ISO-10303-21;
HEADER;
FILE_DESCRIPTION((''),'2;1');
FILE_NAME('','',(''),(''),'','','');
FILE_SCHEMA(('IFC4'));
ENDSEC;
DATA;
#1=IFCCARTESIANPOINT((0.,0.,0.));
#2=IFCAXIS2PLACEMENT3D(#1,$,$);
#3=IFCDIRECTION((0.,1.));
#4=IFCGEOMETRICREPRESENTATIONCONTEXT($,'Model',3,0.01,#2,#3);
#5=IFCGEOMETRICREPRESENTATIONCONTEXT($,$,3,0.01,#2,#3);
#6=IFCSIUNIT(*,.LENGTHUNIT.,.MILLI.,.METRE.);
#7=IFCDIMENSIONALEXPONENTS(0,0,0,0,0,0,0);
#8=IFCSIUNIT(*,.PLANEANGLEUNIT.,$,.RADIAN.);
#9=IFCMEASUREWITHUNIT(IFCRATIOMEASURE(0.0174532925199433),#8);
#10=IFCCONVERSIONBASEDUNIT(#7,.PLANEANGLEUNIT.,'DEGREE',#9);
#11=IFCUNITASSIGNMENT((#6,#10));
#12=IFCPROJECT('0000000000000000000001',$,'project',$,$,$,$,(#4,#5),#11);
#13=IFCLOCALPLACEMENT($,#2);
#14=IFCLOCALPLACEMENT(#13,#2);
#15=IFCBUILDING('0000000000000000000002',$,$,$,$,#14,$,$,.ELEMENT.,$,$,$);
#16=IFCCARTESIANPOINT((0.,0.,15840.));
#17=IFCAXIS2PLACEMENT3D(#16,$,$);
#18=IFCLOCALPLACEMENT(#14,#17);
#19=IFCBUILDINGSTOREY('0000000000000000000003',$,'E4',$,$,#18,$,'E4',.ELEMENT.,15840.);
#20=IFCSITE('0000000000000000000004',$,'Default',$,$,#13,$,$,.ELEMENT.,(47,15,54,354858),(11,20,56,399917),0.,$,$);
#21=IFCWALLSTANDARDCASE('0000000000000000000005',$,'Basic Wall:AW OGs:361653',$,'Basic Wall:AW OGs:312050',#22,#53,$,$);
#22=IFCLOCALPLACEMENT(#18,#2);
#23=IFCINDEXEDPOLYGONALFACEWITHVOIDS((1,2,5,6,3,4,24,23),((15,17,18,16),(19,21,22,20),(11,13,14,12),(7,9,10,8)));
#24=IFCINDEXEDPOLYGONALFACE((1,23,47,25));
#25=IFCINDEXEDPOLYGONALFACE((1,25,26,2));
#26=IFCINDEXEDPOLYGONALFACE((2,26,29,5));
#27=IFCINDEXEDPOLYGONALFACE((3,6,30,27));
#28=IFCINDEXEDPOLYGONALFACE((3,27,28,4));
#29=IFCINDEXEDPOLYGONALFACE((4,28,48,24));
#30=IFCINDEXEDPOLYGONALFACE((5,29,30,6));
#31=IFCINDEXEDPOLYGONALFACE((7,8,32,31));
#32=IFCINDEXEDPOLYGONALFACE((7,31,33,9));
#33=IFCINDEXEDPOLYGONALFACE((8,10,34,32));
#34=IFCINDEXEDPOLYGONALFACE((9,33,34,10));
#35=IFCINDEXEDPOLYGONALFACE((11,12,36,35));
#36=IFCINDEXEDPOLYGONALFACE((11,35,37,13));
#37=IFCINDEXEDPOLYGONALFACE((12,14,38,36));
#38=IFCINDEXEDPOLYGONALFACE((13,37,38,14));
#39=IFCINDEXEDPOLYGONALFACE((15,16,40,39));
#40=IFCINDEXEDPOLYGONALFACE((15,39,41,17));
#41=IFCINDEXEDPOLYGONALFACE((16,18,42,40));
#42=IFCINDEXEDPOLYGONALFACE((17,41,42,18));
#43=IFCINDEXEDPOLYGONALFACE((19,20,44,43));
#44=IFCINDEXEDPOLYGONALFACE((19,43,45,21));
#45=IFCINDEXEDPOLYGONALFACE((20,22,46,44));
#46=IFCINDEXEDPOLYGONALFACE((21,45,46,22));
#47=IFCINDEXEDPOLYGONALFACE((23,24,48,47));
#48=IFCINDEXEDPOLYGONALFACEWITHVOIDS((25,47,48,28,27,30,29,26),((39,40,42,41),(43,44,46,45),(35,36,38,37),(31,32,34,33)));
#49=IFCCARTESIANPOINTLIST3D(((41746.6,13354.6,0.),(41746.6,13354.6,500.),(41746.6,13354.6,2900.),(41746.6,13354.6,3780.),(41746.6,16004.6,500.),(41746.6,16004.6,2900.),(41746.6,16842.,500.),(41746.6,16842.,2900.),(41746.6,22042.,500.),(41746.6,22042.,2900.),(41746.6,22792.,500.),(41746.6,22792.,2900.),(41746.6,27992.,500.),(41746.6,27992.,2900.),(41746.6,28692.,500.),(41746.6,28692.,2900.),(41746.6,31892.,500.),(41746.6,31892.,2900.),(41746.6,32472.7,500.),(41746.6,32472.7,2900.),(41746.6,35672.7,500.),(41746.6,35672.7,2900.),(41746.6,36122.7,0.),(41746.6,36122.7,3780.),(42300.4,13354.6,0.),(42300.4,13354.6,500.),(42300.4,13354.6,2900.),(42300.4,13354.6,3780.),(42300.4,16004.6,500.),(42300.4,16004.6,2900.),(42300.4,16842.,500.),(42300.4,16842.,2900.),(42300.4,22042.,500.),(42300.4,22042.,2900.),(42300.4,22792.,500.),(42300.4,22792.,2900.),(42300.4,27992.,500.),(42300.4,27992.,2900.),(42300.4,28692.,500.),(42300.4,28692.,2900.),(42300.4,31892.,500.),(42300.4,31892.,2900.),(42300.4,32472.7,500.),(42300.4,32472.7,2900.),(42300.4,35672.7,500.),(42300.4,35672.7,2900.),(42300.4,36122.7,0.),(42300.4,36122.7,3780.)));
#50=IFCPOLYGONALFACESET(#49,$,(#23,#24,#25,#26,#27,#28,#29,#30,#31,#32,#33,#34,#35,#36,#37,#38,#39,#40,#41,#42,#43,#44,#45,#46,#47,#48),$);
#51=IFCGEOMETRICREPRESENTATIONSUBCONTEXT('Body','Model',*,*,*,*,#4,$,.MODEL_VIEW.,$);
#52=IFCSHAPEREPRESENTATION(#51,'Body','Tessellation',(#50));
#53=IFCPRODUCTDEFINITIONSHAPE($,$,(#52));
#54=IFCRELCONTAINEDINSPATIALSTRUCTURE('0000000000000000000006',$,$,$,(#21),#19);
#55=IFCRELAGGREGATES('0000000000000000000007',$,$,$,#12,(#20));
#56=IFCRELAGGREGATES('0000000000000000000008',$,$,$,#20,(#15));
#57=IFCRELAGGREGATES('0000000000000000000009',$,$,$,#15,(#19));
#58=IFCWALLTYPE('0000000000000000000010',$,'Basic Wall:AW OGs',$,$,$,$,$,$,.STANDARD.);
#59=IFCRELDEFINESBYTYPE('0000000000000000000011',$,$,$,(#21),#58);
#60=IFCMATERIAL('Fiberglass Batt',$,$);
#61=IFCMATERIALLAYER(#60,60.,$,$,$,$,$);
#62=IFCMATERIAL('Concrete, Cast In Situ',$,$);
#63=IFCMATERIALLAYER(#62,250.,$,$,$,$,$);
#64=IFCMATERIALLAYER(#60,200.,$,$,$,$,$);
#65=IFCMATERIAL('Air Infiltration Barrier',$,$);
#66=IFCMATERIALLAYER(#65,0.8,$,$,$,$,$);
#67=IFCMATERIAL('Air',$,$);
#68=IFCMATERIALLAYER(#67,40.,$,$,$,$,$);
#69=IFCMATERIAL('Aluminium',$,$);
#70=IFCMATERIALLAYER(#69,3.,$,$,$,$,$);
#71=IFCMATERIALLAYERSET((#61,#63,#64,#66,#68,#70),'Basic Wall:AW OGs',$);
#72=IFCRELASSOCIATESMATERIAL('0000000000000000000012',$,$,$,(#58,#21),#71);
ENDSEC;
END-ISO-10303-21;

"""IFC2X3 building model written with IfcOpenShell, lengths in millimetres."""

from ifc_helpers import new_model, entity, si_unit, converted_unit, direction, frame, frame_2d, origin, place, context, subcontext, project, spatial, rectangle, extrude, material, layer, layer_set, layer_usage, type_object, element, save


model = new_model("IFC2X3")

# Units and contexts
model_context = context("Model", 3, precision=0.01, world=origin(), true_north=direction((0.0, 1.0)))
context_of_model = context(None, 3, precision=0.01, world=origin(), true_north=direction((0.0, 1.0)))
body_context = subcontext(model_context, "Body", "Model", "MODEL_VIEW")
ifc_project = project(units=[si_unit("LENGTHUNIT", "METRE", prefix="MILLI"), converted_unit("PLANEANGLEUNIT", "DEGREE", entity("IfcRatioMeasure", 0.0174532925199433), si_unit("PLANEANGLEUNIT", "RADIAN"), dimensions=[0, 0, 0, 0, 0, 0, 0])], contexts=[model_context, context_of_model])

# Site, building, storey
site_placement = place(None, origin())
site = spatial("IfcSite", under=ifc_project, at=site_placement, Name="Default", CompositionType="ELEMENT", RefLatitude=(47, 15, 54, 354858), RefLongitude=(11, 20, 56, 399917), RefElevation=0.0)
building_placement = place(site_placement, origin())
building = spatial("IfcBuilding", under=site, at=building_placement, CompositionType="ELEMENT")
storey_placement = place(building_placement, frame((0.0, 0.0, 15840.0)))
storey = spatial("IfcBuildingStorey", under=building, at=storey_placement, Name="E4", LongName="E4", CompositionType="ELEMENT", Elevation=15840.0)

# Shared definitions
ifc_material_1 = material(Name="Air Infiltration Barrier")
ifc_material_2 = material(Name="Fiberglass Batt")

# Shared definitions
ifc_material_3 = material(Name="Aluminium")

# Wall, openings
ifc_layer_1 = layer(ifc_material_2, 60.0)
ifc_material_4 = material(Name="Concrete, Cast In Situ")
ifc_layer_2 = layer(ifc_material_4, 250.0)
ifc_layer_3 = layer(ifc_material_2, 200.0)
ifc_layer_4 = layer(ifc_material_1, 0.8)
ifc_material_5 = material(Name="Air")
ifc_layer_5 = layer(ifc_material_5, 40.0)
ifc_layer_6 = layer(ifc_material_3, 3.0)
ifc_layer_set_1 = layer_set([ifc_layer_1, ifc_layer_2, ifc_layer_3, ifc_layer_4, ifc_layer_5, ifc_layer_6], Name="Basic Wall:AW OGs")
wall_type = type_object("IfcWallType", Name="Basic Wall:AW OGs", PredefinedType="STANDARD", material=ifc_layer_set_1)
ifc_layer_usage_1 = layer_usage(ifc_layer_set_1, "AXIS2", "NEGATIVE", 276.9)
wall_1_placement = place(storey_placement, frame((42023.5, 36122.7, 0.0), z_axis=(0.0, 0.0, 1.0), x_axis=(0.0, -1.0, 0.0)))
wall_1 = element("IfcWallStandardCase", 1, at=wall_1_placement, inside=storey, type_object=wall_type, material=ifc_layer_usage_1, Name="Basic Wall:AW OGs:361653", ObjectType="Basic Wall:AW OGs:312050", context=body_context, shape_type="SweptSolid", body=[
    extrude(rectangle(XDim=22768.1, YDim=553.8, at=frame_2d((11384.0, 0.0), x_axis=(-1.0, 0.0))), origin(), (0.0, 0.0, 1.0), 3780.0),
])
opening_1_placement = place(wall_1_placement, origin())
element("IfcOpeningElement", 2, at=opening_1_placement, cuts=wall_1, ObjectType="Opening", context=body_context, shape_type="SweptSolid", body=[
    extrude(rectangle(XDim=2400.0, YDim=553.8, at=frame_2d((0.0, 0.0), x_axis=(0.0, 1.0))), frame((23045.0, 276.9, 1700.0), z_axis=(0.0, 1.0, 0.0), x_axis=(1.0, 0.0, 0.0)), (0.0, 0.0, 1.0), 5200.0),
])
opening_2_placement = place(wall_1_placement, frame((22768.1, 276.9, 500.0)))
element("IfcOpeningElement", 3, at=opening_2_placement, cuts=wall_1, ObjectType="Opening", context=body_context, shape_type="SweptSolid", body=[
    extrude(rectangle(XDim=2400.0, YDim=2650.0, at=frame_2d((1200.0, 1325.0), x_axis=(-1.0, 0.0))), frame((0.0, 0.0, 0.0), z_axis=(0.0, -1.0, 0.0), x_axis=(0.0, 0.0, 1.0)), (0.0, 0.0, 1.0), 553.8),
])
opening_3_placement = place(wall_1_placement, frame((19280.7, 276.9, 500.0)))
element("IfcOpeningElement", 4, at=opening_3_placement, cuts=wall_1, ObjectType="Opening", context=body_context, shape_type="SweptSolid", body=[
    extrude(rectangle(XDim=2400.0, YDim=5200.0, at=frame_2d((1200.0, 2600.0), x_axis=(-1.0, 0.0))), frame((0.0, 0.0, 0.0), z_axis=(0.0, -1.0, 0.0), x_axis=(0.0, 0.0, 1.0)), (0.0, 0.0, 1.0), 553.8),
])
opening_4_placement = place(wall_1_placement, frame((13330.7, 276.9, 500.0)))
element("IfcOpeningElement", 5, at=opening_4_placement, cuts=wall_1, ObjectType="Opening", context=body_context, shape_type="SweptSolid", body=[
    extrude(rectangle(XDim=2400.0, YDim=5200.0, at=frame_2d((1200.0, 2600.0), x_axis=(-1.0, 0.0))), frame((0.0, 0.0, 0.0), z_axis=(0.0, -1.0, 0.0), x_axis=(0.0, 0.0, 1.0)), (0.0, 0.0, 1.0), 553.8),
])
opening_5_placement = place(wall_1_placement, frame((7430.7, 276.9, 500.0)))
element("IfcOpeningElement", 6, at=opening_5_placement, cuts=wall_1, ObjectType="Opening", context=body_context, shape_type="SweptSolid", body=[
    extrude(rectangle(XDim=2400.0, YDim=3200.0, at=frame_2d((1200.0, 1600.0), x_axis=(-1.0, 0.0))), frame((0.0, 0.0, 0.0), z_axis=(0.0, -1.0, 0.0), x_axis=(0.0, 0.0, 1.0)), (0.0, 0.0, 1.0), 553.8),
])
opening_6_placement = place(wall_1_placement, frame((3650.0, 276.9, 500.0)))
element("IfcOpeningElement", 7, at=opening_6_placement, cuts=wall_1, ObjectType="Opening", context=body_context, shape_type="SweptSolid", body=[
    extrude(rectangle(XDim=2400.0, YDim=3200.0, at=frame_2d((1200.0, 1600.0), x_axis=(-1.0, 0.0))), frame((0.0, 0.0, 0.0), z_axis=(0.0, -1.0, 0.0), x_axis=(0.0, 0.0, 1.0)), (0.0, 0.0, 1.0), 553.8),
])

save(model, "model.ifc")
